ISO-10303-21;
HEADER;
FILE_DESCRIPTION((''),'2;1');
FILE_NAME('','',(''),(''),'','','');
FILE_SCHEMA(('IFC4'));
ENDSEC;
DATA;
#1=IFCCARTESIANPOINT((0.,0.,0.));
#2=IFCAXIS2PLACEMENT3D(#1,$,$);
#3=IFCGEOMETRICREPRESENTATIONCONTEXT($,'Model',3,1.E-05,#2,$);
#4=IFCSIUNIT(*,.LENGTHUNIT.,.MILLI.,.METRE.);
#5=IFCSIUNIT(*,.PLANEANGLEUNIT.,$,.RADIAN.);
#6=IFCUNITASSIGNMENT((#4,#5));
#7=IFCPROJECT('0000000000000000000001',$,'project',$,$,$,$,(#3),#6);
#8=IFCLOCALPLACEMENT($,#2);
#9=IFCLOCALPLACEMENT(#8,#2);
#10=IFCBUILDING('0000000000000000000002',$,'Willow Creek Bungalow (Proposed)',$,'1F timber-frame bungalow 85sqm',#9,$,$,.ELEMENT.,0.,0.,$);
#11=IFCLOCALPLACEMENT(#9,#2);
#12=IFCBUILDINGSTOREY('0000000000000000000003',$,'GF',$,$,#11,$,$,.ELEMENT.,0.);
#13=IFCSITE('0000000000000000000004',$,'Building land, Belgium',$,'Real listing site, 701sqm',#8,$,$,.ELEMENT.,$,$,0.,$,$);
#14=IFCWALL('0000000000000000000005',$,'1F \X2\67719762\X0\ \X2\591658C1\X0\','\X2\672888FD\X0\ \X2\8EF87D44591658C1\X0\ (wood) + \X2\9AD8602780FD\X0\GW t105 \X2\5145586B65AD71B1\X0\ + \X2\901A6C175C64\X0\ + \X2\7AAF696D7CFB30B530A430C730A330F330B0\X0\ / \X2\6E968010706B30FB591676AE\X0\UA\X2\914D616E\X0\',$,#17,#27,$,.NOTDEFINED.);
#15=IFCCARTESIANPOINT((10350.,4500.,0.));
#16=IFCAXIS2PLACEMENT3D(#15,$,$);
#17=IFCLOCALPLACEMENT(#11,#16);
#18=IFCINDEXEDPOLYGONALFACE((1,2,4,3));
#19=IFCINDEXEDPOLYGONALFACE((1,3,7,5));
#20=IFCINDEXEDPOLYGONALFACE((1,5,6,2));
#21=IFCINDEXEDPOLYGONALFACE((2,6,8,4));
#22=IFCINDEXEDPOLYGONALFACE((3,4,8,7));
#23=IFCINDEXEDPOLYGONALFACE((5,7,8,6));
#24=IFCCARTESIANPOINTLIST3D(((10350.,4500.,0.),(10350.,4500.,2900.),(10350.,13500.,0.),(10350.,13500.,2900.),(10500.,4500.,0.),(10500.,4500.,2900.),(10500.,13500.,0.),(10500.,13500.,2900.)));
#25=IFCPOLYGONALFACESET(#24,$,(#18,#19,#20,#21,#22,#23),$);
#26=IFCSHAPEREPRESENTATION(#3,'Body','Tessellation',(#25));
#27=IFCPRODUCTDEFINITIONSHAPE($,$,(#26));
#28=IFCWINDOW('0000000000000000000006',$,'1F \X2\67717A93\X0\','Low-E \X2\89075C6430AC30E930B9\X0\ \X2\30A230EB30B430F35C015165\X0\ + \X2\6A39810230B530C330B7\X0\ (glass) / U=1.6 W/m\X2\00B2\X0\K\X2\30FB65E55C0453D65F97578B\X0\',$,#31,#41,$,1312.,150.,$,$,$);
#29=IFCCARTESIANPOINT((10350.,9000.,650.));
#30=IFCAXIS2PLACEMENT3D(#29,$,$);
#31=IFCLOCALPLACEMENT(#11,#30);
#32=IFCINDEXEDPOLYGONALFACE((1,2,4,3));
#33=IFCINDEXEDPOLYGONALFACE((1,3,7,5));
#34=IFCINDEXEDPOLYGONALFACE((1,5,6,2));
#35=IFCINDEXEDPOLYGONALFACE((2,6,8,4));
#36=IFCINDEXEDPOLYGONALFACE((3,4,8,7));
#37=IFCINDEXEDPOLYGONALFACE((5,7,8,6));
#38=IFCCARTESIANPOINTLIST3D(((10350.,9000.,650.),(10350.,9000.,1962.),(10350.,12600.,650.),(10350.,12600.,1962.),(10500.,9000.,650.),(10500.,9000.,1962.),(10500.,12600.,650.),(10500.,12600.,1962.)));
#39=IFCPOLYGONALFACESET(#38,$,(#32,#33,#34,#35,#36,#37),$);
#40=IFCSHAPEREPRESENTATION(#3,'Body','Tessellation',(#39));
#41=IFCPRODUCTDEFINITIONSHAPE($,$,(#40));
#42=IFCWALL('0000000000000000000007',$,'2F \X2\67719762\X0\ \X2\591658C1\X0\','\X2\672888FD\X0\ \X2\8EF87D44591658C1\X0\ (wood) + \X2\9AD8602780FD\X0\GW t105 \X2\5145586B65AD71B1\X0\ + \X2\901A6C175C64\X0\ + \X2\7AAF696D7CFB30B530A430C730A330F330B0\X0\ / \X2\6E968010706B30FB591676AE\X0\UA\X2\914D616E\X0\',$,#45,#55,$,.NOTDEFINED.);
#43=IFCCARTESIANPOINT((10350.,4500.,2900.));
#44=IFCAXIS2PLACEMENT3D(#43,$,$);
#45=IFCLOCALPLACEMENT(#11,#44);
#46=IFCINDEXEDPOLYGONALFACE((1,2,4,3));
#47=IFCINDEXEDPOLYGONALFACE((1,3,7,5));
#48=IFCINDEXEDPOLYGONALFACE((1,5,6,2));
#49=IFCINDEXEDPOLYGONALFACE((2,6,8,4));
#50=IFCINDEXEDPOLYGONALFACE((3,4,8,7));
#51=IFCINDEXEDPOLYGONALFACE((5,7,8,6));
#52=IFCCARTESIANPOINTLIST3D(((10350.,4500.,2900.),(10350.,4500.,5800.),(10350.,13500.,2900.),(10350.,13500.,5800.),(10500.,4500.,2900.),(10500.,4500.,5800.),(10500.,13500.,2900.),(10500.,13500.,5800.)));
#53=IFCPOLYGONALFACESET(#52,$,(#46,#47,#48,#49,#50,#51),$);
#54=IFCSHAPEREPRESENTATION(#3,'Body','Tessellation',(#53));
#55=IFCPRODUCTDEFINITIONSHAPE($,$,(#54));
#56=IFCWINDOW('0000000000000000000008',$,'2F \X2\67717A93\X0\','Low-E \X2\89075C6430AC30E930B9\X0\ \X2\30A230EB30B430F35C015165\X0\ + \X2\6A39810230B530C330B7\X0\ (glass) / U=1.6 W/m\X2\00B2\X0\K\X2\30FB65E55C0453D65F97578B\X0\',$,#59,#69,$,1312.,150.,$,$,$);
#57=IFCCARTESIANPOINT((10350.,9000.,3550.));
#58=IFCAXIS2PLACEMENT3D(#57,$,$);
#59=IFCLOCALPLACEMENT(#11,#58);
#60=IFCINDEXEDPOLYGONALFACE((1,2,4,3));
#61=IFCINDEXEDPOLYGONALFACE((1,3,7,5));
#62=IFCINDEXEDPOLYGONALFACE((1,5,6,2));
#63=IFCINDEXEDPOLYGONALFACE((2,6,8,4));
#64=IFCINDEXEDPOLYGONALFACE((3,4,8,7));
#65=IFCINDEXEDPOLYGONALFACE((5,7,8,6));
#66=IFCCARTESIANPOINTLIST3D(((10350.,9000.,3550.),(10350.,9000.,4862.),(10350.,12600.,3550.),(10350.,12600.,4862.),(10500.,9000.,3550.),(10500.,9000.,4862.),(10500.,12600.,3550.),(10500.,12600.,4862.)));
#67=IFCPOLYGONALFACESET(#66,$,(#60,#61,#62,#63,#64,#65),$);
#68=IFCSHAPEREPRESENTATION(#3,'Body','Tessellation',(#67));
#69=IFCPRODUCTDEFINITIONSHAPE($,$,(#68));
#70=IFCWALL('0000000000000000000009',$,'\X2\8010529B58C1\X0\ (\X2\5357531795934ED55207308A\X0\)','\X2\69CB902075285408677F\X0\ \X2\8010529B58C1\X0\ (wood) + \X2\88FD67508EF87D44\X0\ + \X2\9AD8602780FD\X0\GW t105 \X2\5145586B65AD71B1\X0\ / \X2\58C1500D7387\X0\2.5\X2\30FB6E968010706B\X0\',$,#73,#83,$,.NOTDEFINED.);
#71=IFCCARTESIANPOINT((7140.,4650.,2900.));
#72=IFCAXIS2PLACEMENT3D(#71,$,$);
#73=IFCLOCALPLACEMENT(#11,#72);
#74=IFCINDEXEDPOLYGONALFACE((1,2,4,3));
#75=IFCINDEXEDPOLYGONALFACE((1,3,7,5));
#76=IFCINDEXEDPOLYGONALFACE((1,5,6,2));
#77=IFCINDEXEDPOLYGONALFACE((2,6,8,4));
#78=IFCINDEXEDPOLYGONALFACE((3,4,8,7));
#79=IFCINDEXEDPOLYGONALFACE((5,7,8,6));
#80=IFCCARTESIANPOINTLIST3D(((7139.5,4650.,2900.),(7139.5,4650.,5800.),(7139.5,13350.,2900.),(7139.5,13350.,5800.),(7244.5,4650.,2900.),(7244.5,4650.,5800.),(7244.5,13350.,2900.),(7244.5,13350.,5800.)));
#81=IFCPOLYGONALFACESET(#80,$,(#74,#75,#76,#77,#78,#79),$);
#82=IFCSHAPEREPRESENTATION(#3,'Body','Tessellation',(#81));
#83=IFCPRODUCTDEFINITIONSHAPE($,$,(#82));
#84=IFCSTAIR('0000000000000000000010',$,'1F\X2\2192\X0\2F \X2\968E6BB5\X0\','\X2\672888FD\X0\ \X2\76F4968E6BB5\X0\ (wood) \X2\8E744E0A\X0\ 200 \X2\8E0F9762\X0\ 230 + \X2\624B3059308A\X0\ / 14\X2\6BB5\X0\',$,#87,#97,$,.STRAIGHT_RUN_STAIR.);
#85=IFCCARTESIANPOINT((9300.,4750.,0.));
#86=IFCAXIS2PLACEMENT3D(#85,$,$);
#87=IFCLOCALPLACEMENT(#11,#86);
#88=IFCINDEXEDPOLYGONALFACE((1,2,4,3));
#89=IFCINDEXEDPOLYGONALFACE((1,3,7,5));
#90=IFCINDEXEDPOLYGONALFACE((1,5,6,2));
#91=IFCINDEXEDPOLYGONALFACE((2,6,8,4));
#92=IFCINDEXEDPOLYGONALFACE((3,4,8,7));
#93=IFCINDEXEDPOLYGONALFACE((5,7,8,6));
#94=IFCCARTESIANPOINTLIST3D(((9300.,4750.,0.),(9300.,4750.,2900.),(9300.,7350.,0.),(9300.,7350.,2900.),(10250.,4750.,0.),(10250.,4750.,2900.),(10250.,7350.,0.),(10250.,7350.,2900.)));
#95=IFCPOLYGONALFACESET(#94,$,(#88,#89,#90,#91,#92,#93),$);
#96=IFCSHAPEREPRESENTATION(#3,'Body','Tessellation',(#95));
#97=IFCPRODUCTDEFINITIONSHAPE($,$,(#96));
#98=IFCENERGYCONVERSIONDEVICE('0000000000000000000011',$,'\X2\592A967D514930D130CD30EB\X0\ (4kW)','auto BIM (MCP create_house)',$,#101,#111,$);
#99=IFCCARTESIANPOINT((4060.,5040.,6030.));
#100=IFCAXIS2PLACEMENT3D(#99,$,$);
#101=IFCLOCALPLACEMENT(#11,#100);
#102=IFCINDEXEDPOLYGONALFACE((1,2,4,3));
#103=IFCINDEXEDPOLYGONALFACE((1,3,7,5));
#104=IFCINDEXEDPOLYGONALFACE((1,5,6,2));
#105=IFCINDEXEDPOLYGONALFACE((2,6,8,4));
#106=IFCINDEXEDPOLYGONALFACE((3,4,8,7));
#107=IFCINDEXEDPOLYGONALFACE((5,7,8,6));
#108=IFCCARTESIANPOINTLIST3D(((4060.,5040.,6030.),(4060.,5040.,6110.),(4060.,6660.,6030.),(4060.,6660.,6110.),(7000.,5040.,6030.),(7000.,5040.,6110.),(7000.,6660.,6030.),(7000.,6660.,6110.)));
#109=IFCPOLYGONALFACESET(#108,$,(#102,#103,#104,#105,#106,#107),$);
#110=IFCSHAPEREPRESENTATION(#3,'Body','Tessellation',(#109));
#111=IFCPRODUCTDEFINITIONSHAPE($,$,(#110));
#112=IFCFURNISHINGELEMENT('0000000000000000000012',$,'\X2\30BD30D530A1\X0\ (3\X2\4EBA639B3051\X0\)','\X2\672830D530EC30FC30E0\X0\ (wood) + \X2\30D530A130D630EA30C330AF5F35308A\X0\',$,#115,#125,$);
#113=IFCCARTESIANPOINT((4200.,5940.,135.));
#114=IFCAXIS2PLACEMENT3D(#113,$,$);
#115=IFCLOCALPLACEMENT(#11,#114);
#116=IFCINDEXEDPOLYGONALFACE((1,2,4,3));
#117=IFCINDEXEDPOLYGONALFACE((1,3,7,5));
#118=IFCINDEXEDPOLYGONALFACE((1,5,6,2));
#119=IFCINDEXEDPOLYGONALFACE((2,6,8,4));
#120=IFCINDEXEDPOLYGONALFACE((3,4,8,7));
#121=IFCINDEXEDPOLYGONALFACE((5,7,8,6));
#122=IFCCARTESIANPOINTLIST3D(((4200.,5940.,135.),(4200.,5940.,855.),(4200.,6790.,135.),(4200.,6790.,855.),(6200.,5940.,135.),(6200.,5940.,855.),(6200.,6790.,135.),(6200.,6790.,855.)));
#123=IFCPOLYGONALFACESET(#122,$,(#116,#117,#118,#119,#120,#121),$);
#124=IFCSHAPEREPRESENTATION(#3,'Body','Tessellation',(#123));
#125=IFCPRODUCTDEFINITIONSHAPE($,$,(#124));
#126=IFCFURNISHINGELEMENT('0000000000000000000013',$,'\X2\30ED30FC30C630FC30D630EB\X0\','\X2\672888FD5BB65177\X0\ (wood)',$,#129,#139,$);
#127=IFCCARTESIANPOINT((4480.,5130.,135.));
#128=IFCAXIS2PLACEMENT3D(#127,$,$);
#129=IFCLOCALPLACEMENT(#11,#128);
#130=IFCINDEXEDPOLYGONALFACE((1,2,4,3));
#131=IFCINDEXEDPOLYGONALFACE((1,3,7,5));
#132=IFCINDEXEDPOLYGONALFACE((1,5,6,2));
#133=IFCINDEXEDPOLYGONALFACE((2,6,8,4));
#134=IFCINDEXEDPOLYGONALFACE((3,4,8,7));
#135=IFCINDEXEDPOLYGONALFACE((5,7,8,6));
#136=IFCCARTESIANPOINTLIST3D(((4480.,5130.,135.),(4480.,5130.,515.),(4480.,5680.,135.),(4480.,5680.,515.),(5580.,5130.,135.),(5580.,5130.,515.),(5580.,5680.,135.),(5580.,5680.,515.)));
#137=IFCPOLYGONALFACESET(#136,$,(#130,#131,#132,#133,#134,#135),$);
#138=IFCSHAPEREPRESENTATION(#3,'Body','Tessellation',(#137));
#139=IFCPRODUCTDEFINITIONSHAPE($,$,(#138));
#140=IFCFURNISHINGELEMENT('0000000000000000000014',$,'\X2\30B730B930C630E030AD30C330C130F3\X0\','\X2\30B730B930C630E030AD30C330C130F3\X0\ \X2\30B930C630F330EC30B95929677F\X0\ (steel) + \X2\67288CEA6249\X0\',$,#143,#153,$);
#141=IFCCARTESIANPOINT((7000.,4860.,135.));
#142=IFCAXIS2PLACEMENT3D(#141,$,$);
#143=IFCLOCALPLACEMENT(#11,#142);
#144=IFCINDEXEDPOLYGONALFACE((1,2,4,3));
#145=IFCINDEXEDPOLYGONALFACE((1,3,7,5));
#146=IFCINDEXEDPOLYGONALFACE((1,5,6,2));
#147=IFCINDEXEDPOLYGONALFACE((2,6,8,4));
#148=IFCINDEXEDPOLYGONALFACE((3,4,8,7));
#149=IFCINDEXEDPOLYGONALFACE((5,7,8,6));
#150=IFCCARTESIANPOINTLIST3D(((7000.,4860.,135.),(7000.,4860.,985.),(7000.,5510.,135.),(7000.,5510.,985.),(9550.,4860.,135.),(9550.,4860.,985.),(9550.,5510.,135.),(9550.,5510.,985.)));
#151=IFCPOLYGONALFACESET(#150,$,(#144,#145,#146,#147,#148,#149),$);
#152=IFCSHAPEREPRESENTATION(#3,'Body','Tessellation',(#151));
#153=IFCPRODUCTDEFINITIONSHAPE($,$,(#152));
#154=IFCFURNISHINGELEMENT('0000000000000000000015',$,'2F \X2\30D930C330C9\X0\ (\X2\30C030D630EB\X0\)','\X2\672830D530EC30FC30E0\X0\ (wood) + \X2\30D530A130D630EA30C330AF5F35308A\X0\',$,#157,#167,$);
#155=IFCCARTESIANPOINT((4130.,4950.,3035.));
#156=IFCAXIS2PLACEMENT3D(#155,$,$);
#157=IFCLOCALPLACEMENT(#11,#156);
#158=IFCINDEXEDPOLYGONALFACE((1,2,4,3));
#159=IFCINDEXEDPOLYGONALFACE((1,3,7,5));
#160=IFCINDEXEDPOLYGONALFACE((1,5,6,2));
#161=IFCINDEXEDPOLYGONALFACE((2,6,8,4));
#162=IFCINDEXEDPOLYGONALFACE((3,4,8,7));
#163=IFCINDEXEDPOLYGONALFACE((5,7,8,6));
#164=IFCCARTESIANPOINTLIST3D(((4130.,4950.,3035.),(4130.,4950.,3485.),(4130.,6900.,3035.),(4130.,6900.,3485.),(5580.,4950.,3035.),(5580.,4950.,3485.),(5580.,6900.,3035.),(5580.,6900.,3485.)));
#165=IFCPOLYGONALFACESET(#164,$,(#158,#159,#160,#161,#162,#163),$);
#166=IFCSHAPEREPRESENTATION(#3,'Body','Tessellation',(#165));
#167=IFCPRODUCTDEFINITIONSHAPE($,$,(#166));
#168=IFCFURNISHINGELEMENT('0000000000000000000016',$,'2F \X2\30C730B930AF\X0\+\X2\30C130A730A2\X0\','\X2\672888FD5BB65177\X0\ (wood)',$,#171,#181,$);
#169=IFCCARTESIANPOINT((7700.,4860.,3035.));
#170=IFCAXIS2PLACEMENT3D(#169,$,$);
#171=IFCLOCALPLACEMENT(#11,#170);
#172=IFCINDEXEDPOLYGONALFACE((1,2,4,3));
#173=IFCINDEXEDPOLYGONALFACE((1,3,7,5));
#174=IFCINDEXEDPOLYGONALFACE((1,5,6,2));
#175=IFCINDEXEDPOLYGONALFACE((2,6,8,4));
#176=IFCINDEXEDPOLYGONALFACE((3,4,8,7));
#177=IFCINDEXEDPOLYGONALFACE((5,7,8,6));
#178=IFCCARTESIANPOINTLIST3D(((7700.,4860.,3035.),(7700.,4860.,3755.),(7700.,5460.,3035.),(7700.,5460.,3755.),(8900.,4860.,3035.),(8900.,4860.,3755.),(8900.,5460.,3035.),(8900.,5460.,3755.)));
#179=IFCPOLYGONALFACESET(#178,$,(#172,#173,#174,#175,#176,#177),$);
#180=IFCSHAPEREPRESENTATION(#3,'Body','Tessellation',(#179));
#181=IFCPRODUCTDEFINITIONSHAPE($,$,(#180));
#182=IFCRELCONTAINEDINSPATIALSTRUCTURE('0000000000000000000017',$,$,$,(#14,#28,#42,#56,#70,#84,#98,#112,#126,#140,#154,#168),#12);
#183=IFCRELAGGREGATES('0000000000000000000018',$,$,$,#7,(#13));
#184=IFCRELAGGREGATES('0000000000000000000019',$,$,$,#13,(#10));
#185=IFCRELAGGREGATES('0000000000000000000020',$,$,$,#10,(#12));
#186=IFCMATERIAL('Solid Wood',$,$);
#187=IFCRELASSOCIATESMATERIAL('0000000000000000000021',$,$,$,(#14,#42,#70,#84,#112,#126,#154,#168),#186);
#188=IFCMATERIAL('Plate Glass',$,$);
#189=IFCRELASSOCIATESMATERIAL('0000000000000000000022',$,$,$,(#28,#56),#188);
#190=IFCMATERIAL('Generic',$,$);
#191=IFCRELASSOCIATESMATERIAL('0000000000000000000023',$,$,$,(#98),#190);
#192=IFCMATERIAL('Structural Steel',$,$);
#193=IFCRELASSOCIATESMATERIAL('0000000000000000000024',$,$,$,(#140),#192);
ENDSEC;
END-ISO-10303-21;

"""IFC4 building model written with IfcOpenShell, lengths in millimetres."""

from ifc_helpers import new_model, si_unit, frame, frame_2d, origin, place, context, project, spatial, rectangle, extrude, material, element, fill, save


model = new_model("IFC4")

# Units and contexts
model_context = context("Model", 3, precision=1e-05, world=origin())
ifc_project = project(units=[si_unit("LENGTHUNIT", "METRE", prefix="MILLI"), si_unit("PLANEANGLEUNIT", "RADIAN")], contexts=[model_context])

# Site, building, storey
site_placement = place(None, origin())
site = spatial("IfcSite", under=ifc_project, at=site_placement, Name="Building land, Belgium", ObjectType="Real listing site, 701sqm", CompositionType="ELEMENT", RefElevation=0.0)
building_placement = place(site_placement, origin())
building = spatial("IfcBuilding", under=site, at=building_placement, Name="Willow Creek Bungalow (Proposed)", ObjectType="1F timber-frame bungalow 85sqm", CompositionType="ELEMENT", ElevationOfRefHeight=0.0, ElevationOfTerrain=0.0)
storey_placement = place(building_placement, origin())
storey = spatial("IfcBuildingStorey", under=building, at=storey_placement, Name="GF", CompositionType="ELEMENT", Elevation=0.0)

# Wall, opening, window
ifc_material_1 = material(Name="Solid Wood")
wall_1_placement = place(storey_placement, frame((10350.0, 4500.0, 0.0)))
wall_1 = element("IfcWall", 1, at=wall_1_placement, inside=storey, material=ifc_material_1, Name="1F 東面 外壁", Description="木製 軸組外壁 (wood) + 高性能GW t105 充填断熱 + 通気層 + 窯業系サイディング / 準耐火・外皮UA配慮", PredefinedType="NOTDEFINED", context=model_context, shape_type="SweptSolid", body=[
    extrude(rectangle(XDim=150.0, YDim=9000.0, at=frame_2d((75.0, 4500.0))), frame((10350.0, 4500.0, 0.0)), (0.0, 0.0, 1.0), 2900.0),
])
opening_1_placement = place(storey_placement, frame((10350.0, 9000.0, 650.0)))
opening_1 = element("IfcOpeningElement", 2, at=opening_1_placement, cuts=wall_1, PredefinedType="NOTDEFINED", context=model_context, shape_type="SweptSolid", body=[
    extrude(rectangle(XDim=150.0, YDim=3600.0, at=frame_2d((75.0, 1800.0))), frame((10350.0, 9000.0, 650.0)), (0.0, 0.0, 1.0), 1312.0),
])
ifc_material_2 = material(Name="Plate Glass")
window_1_placement = place(storey_placement, frame((10350.0, 9000.0, 650.0)))
window_1 = element("IfcWindow", 3, at=window_1_placement, inside=storey, material=ifc_material_2, Name="1F 東窓", Description="Low-E 複層ガラス アルゴン封入 + 樹脂サッシ (glass) / U=1.6 W/m²K・日射取得型", OverallHeight=1312.0, OverallWidth=150.0, context=model_context, shape_type="SweptSolid", body=[
    extrude(rectangle(XDim=150.0, YDim=3600.0, at=frame_2d((75.0, 1800.0))), frame((10350.0, 9000.0, 650.0)), (0.0, 0.0, 1.0), 1312.0),
])
fill(opening_1, window_1)

# Wall, opening, window
wall_2_placement = place(storey_placement, frame((10350.0, 4500.0, 2900.0)))
wall_2 = element("IfcWall", 4, at=wall_2_placement, inside=storey, material=ifc_material_1, Name="2F 東面 外壁", Description="木製 軸組外壁 (wood) + 高性能GW t105 充填断熱 + 通気層 + 窯業系サイディング / 準耐火・外皮UA配慮", PredefinedType="NOTDEFINED", context=model_context, shape_type="SweptSolid", body=[
    extrude(rectangle(XDim=150.0, YDim=9000.0, at=frame_2d((75.0, 4500.0))), frame((10350.0, 4500.0, 2900.0)), (0.0, 0.0, 1.0), 2900.0),
])
opening_2_placement = place(storey_placement, frame((10350.0, 9000.0, 3550.0)))
opening_2 = element("IfcOpeningElement", 5, at=opening_2_placement, cuts=wall_2, PredefinedType="NOTDEFINED", context=model_context, shape_type="SweptSolid", body=[
    extrude(rectangle(XDim=150.0, YDim=3600.0, at=frame_2d((75.0, 1800.0))), frame((10350.0, 9000.0, 3550.0)), (0.0, 0.0, 1.0), 1312.0),
])
window_2_placement = place(storey_placement, frame((10350.0, 9000.0, 3550.0)))
window_2 = element("IfcWindow", 6, at=window_2_placement, inside=storey, material=ifc_material_2, Name="2F 東窓", Description="Low-E 複層ガラス アルゴン封入 + 樹脂サッシ (glass) / U=1.6 W/m²K・日射取得型", OverallHeight=1312.0, OverallWidth=150.0, context=model_context, shape_type="SweptSolid", body=[
    extrude(rectangle(XDim=150.0, YDim=3600.0, at=frame_2d((75.0, 1800.0))), frame((10350.0, 9000.0, 3550.0)), (0.0, 0.0, 1.0), 1312.0),
])
fill(opening_2, window_2)

# Wall
wall_3_placement = place(storey_placement, frame((7140.0, 4650.0, 2900.0)))
element("IfcWall", 7, at=wall_3_placement, inside=storey, material=ifc_material_1, Name="耐力壁 (南北間仕切り)", Description="構造用合板 耐力壁 (wood) + 製材軸組 + 高性能GW t105 充填断熱 / 壁倍率2.5・準耐火", PredefinedType="NOTDEFINED", context=model_context, shape_type="SweptSolid", body=[
    extrude(rectangle(XDim=105.0, YDim=8700.0, at=frame_2d((52.0, 4350.0))), frame((7140.0, 4650.0, 2900.0)), (0.0, 0.0, 1.0), 2900.0),
])

# Stair
stair_placement = place(storey_placement, frame((9300.0, 4750.0, 0.0)))
element("IfcStair", 8, at=stair_placement, inside=storey, material=ifc_material_1, Name="1F→2F 階段", Description="木製 直階段 (wood) 蹴上 200 踏面 230 + 手すり / 14段", PredefinedType="STRAIGHT_RUN_STAIR", context=model_context, shape_type="SweptSolid", body=[
    extrude(rectangle(XDim=950.0, YDim=2600.0, at=frame_2d((475.0, 1300.0))), frame((9300.0, 4750.0, 0.0)), (0.0, 0.0, 1.0), 2900.0),
])

# Energy conversion device
ifc_material_3 = material(Name="Generic")
energy_conversion_device_placement = place(storey_placement, frame((4060.0, 5040.0, 6030.0)))
element("IfcEnergyConversionDevice", 9, at=energy_conversion_device_placement, inside=storey, material=ifc_material_3, Name="太陽光パネル (4kW)", Description="auto BIM (MCP create_house)", context=model_context, shape_type="SweptSolid", body=[
    extrude(rectangle(XDim=2940.0, YDim=1620.0, at=frame_2d((1470.0, 810.0))), frame((4060.0, 5040.0, 6030.0)), (0.0, 0.0, 1.0), 80.0),
])

# Furnishing elements
furnishing_1_placement = place(storey_placement, frame((4200.0, 5940.0, 135.0)))
element("IfcFurnishingElement", 10, at=furnishing_1_placement, inside=storey, material=ifc_material_1, Name="ソファ (3人掛け)", Description="木フレーム (wood) + ファブリック張り", context=model_context, shape_type="SweptSolid", body=[
    extrude(rectangle(XDim=2000.0, YDim=850.0, at=frame_2d((1000.0, 425.0))), frame((4200.0, 5940.0, 135.0)), (0.0, 0.0, 1.0), 720.0),
])
furnishing_2_placement = place(storey_placement, frame((4480.0, 5130.0, 135.0)))
element("IfcFurnishingElement", 11, at=furnishing_2_placement, inside=storey, material=ifc_material_1, Name="ローテーブル", Description="木製家具 (wood)", context=model_context, shape_type="SweptSolid", body=[
    extrude(rectangle(XDim=1100.0, YDim=550.0, at=frame_2d((550.0, 275.0))), frame((4480.0, 5130.0, 135.0)), (0.0, 0.0, 1.0), 380.0),
])
ifc_material_4 = material(Name="Structural Steel")
furnishing_3_placement = place(storey_placement, frame((7000.0, 4860.0, 135.0)))
element("IfcFurnishingElement", 12, at=furnishing_3_placement, inside=storey, material=ifc_material_4, Name="システムキッチン", Description="システムキッチン ステンレス天板 (steel) + 木質扉", context=model_context, shape_type="SweptSolid", body=[
    extrude(rectangle(XDim=2550.0, YDim=650.0, at=frame_2d((1275.0, 325.0))), frame((7000.0, 4860.0, 135.0)), (0.0, 0.0, 1.0), 850.0),
])
furnishing_4_placement = place(storey_placement, frame((4130.0, 4950.0, 3035.0)))
element("IfcFurnishingElement", 13, at=furnishing_4_placement, inside=storey, material=ifc_material_1, Name="2F ベッド (ダブル)", Description="木フレーム (wood) + ファブリック張り", context=model_context, shape_type="SweptSolid", body=[
    extrude(rectangle(XDim=1450.0, YDim=1950.0, at=frame_2d((725.0, 975.0))), frame((4130.0, 4950.0, 3035.0)), (0.0, 0.0, 1.0), 450.0),
])
furnishing_5_placement = place(storey_placement, frame((7700.0, 4860.0, 3035.0)))
element("IfcFurnishingElement", 14, at=furnishing_5_placement, inside=storey, material=ifc_material_1, Name="2F デスク+チェア", Description="木製家具 (wood)", context=model_context, shape_type="SweptSolid", body=[
    extrude(rectangle(XDim=1200.0, YDim=600.0, at=frame_2d((600.0, 300.0))), frame((7700.0, 4860.0, 3035.0)), (0.0, 0.0, 1.0), 720.0),
])

save(model, "model.ifc")
